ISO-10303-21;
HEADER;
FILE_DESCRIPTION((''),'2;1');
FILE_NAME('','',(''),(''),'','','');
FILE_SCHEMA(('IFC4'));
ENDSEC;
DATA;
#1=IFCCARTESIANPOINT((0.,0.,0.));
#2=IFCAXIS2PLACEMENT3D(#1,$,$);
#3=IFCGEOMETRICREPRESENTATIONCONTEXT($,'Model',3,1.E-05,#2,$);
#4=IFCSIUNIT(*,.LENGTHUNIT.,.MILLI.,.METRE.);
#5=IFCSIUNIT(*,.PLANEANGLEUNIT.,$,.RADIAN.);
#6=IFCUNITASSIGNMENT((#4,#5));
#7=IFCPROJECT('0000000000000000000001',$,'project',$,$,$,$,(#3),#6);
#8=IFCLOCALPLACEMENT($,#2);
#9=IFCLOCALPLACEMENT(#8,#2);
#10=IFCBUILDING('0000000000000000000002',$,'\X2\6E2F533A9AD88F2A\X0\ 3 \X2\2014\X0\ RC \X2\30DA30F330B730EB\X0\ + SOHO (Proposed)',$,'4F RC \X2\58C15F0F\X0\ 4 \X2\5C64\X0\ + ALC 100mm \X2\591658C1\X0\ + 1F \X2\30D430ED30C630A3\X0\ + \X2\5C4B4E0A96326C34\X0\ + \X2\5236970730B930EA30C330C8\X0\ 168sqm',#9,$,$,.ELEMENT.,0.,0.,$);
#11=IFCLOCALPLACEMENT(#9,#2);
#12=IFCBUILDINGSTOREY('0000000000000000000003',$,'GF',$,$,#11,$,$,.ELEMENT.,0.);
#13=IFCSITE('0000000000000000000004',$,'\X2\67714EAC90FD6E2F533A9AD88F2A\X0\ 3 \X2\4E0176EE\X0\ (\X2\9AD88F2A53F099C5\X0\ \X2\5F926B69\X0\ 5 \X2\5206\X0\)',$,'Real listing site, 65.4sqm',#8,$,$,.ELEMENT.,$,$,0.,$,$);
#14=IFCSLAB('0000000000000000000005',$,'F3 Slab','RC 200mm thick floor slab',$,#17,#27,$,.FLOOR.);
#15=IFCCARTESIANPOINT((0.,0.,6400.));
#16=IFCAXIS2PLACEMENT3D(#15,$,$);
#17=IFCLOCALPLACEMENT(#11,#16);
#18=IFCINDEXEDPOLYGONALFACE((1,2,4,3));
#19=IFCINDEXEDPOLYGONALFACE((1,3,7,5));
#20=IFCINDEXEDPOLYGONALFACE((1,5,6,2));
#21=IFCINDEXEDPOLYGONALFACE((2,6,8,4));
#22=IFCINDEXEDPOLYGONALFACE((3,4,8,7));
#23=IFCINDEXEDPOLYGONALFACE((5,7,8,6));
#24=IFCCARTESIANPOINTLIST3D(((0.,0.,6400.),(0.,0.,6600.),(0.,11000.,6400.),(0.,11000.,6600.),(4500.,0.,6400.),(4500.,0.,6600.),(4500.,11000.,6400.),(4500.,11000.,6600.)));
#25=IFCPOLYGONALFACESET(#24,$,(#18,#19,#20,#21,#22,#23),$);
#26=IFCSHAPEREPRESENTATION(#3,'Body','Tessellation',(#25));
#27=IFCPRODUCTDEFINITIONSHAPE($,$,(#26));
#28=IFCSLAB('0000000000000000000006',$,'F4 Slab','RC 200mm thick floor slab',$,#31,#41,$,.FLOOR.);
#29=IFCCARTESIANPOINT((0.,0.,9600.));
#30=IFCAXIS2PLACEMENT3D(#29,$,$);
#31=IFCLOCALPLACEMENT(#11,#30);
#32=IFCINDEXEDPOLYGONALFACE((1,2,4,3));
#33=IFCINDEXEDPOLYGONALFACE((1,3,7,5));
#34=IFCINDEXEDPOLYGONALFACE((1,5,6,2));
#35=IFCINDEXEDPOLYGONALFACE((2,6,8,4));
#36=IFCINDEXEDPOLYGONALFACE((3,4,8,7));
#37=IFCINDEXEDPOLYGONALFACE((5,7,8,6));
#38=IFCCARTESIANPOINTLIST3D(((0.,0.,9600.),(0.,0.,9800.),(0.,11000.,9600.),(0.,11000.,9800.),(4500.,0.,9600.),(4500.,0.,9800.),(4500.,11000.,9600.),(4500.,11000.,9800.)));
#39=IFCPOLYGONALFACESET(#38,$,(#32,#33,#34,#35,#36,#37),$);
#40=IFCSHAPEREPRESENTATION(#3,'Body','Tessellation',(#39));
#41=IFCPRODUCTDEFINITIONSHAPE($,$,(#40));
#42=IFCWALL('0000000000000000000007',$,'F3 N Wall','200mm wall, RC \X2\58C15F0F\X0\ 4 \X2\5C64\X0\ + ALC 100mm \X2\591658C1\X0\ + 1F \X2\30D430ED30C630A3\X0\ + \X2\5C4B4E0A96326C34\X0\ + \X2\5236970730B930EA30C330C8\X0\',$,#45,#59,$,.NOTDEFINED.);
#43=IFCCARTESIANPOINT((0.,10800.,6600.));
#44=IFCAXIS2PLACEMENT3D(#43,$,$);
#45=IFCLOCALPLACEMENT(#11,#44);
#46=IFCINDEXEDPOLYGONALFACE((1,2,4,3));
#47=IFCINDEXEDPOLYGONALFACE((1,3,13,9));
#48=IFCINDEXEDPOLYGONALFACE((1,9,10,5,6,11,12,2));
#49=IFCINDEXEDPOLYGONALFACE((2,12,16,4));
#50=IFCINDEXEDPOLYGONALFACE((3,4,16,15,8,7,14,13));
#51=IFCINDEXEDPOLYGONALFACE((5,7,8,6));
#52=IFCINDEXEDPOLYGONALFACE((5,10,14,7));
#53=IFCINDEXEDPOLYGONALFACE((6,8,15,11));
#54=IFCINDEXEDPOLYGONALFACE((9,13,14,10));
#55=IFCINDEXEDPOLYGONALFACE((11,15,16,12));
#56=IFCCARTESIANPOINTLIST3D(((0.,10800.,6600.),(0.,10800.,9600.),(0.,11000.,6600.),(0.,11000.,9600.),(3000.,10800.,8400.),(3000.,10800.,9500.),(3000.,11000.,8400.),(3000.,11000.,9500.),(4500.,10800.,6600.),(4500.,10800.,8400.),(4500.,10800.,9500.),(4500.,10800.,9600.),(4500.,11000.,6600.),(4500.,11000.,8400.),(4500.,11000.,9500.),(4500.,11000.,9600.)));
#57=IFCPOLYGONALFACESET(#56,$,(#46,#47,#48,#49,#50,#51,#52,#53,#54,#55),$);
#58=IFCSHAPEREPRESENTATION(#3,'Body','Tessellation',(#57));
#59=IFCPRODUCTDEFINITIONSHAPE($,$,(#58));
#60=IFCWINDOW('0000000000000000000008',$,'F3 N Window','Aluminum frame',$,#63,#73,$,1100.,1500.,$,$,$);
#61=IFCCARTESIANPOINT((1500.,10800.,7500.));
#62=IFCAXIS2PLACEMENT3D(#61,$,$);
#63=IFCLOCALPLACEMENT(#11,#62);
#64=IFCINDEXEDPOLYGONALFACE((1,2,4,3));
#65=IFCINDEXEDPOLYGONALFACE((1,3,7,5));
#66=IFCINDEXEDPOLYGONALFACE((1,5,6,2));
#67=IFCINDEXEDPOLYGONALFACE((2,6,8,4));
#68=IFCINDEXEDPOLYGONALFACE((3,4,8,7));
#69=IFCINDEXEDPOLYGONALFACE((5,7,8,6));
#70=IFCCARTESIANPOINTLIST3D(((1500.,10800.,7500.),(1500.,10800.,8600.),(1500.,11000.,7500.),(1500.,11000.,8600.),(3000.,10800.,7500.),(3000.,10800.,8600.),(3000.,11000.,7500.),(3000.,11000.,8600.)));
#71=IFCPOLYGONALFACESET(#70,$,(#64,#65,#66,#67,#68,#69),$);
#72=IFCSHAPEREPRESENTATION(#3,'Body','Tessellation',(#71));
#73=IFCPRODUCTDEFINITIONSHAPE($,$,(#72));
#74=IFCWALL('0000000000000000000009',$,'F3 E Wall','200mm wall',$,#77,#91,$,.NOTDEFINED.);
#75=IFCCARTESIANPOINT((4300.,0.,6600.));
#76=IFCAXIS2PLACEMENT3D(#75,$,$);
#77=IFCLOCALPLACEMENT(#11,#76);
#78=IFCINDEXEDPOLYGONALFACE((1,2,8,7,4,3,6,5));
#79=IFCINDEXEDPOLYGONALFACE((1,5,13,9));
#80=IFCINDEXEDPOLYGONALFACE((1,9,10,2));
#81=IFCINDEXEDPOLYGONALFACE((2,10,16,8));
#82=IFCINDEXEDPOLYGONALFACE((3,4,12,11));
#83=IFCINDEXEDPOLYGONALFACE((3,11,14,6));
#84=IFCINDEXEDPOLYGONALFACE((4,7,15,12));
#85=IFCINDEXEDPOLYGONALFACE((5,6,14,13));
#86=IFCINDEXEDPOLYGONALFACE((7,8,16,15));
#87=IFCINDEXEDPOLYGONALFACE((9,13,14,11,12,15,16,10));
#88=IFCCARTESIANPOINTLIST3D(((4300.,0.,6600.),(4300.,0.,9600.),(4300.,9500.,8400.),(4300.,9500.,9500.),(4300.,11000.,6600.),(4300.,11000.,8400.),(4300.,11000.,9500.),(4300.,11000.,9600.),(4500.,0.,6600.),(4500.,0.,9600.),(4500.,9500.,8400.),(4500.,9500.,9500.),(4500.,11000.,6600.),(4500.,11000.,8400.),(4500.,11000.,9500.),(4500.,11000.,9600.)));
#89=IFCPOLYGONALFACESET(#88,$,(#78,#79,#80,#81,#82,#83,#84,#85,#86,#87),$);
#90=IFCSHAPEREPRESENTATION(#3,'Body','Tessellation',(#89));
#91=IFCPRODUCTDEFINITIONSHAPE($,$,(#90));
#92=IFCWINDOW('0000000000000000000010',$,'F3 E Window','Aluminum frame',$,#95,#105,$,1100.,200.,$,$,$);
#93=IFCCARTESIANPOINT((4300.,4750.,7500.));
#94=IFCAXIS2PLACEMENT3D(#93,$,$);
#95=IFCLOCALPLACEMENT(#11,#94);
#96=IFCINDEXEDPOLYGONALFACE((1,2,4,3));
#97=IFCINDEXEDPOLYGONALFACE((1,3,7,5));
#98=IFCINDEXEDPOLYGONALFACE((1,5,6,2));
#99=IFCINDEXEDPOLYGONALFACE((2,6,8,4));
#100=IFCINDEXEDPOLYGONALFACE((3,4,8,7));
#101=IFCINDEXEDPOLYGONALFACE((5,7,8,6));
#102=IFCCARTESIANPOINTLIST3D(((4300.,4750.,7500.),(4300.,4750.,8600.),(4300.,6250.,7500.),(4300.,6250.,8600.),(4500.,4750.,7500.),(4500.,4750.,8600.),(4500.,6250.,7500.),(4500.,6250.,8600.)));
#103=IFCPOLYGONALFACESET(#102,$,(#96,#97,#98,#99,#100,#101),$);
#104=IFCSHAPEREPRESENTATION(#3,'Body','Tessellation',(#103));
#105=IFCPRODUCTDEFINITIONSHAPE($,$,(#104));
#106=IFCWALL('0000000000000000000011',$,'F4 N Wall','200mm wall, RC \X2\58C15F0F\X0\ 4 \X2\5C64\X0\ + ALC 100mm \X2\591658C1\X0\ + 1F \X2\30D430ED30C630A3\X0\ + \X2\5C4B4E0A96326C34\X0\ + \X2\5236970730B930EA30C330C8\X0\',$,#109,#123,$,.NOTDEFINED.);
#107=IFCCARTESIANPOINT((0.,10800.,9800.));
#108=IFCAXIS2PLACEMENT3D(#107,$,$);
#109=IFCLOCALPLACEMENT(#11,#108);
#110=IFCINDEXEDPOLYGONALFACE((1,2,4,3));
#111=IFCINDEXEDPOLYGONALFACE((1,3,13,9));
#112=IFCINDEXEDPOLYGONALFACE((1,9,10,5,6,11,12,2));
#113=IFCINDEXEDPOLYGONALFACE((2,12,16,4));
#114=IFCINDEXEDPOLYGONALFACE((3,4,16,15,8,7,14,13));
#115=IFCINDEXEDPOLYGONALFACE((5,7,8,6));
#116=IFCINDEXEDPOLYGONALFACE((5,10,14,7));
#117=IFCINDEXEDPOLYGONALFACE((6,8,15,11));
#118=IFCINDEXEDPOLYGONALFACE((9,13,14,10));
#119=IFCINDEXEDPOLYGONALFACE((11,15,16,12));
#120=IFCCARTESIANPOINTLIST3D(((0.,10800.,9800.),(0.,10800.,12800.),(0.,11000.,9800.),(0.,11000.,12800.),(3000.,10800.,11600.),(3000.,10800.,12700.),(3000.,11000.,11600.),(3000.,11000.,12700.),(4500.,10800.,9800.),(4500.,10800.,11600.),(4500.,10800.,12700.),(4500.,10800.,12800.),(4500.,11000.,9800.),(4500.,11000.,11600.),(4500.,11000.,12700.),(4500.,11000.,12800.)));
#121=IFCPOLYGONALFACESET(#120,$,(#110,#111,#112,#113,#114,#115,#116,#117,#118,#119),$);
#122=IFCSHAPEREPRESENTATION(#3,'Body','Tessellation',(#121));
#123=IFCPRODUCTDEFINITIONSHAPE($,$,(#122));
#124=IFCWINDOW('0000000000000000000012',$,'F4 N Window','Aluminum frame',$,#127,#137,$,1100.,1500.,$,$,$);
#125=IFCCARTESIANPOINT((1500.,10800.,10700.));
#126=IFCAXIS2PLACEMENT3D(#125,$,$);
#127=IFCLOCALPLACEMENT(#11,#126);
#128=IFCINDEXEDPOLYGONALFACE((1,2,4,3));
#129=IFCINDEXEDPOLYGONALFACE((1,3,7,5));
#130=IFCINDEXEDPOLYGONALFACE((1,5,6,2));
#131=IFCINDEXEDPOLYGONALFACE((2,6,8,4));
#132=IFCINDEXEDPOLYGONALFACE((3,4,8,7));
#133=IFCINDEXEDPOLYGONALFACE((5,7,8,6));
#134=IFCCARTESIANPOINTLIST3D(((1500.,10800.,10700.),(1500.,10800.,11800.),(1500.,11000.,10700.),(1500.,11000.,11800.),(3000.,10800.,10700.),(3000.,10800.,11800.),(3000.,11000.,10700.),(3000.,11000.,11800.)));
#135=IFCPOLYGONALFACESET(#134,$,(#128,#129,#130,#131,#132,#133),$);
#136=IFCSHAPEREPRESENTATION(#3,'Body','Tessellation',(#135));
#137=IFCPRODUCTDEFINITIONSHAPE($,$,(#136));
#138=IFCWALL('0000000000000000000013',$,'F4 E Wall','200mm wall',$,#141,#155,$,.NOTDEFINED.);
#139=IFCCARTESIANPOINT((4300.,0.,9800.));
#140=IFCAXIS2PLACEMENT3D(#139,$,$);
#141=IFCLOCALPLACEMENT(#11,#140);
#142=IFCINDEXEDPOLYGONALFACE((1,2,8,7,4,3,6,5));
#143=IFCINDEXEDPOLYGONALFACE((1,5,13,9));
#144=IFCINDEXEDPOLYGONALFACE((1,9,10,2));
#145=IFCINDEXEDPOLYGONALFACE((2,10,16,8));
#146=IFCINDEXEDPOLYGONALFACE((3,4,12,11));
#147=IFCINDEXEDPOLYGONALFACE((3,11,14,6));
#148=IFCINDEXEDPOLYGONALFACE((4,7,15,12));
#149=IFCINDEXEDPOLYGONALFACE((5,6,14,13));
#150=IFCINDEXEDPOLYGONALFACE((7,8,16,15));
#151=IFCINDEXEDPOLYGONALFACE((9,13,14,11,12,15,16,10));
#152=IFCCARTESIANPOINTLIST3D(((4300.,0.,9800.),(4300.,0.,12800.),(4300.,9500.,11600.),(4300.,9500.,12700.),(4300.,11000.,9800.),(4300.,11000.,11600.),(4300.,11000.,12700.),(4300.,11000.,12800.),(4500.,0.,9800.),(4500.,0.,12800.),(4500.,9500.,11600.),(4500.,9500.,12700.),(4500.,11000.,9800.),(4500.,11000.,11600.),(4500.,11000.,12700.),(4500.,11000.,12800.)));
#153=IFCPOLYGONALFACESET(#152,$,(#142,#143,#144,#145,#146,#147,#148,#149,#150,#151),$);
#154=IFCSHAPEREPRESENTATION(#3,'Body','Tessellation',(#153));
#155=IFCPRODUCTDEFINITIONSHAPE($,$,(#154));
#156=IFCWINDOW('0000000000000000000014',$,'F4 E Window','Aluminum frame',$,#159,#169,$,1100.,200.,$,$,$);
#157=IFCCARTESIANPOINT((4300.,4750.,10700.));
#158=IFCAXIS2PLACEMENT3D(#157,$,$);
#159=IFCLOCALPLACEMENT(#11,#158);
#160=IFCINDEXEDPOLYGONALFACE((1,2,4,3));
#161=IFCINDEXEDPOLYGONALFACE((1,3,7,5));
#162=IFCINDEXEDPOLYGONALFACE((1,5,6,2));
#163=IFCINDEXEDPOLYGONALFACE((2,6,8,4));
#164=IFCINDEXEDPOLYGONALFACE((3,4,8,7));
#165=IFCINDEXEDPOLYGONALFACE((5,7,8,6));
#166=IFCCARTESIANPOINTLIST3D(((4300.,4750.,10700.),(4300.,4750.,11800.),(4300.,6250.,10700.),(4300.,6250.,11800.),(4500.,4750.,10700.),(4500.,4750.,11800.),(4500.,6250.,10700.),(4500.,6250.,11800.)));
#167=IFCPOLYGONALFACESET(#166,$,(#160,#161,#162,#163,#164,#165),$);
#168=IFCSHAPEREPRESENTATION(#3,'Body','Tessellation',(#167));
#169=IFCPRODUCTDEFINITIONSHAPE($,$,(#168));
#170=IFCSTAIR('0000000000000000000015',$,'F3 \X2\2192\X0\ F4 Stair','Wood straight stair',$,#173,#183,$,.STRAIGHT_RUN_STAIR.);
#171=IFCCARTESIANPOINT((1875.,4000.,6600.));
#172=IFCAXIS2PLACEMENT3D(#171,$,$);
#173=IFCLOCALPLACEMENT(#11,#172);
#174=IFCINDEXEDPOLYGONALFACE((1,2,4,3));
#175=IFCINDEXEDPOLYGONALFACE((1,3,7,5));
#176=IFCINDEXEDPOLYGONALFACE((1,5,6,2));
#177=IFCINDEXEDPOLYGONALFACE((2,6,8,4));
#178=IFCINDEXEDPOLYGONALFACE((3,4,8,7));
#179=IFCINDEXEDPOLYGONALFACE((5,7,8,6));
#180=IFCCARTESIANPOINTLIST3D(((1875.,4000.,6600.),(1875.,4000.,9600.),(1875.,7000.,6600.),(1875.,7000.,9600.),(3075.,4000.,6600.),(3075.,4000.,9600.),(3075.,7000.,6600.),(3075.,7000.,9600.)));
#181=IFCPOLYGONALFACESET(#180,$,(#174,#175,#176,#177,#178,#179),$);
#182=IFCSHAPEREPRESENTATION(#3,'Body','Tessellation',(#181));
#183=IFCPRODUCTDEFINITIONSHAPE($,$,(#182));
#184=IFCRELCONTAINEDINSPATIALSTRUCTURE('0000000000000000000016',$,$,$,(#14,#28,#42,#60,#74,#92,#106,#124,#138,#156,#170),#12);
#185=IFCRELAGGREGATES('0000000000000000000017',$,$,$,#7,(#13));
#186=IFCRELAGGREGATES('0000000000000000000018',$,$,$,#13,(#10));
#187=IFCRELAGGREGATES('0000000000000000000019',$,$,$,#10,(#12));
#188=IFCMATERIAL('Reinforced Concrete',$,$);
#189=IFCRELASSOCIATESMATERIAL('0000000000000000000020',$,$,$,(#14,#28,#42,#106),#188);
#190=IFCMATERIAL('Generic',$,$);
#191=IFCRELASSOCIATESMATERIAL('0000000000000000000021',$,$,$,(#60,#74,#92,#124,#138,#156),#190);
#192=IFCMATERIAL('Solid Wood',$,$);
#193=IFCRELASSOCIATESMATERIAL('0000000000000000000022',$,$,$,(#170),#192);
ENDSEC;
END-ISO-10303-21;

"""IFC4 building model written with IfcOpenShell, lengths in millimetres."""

from ifc_helpers import new_model, si_unit, frame, frame_2d, origin, place, context, project, spatial, rectangle, extrude, material, element, fill, save


model = new_model("IFC4")

# Units and contexts
model_context = context("Model", 3, precision=1e-05, world=origin())
ifc_project = project(units=[si_unit("LENGTHUNIT", "METRE", prefix="MILLI"), si_unit("PLANEANGLEUNIT", "RADIAN")], contexts=[model_context])

# Site, building, storey
site_placement = place(None, origin())
site = spatial("IfcSite", under=ifc_project, at=site_placement, Name="東京都港区高輪 3 丁目 (高輪台駅 徒歩 5 分)", ObjectType="Real listing site, 65.4sqm", CompositionType="ELEMENT", RefElevation=0.0)
building_placement = place(site_placement, origin())
building = spatial("IfcBuilding", under=site, at=building_placement, Name="港区高輪 3 — RC ペンシル + SOHO (Proposed)", ObjectType="4F RC 壁式 4 層 + ALC 100mm 外壁 + 1F ピロティ + 屋上防水 + 制震スリット 168sqm", CompositionType="ELEMENT", ElevationOfRefHeight=0.0, ElevationOfTerrain=0.0)
storey_placement = place(building_placement, origin())
storey = spatial("IfcBuildingStorey", under=building, at=storey_placement, Name="GF", CompositionType="ELEMENT", Elevation=0.0)

# Slabs
ifc_material_1 = material(Name="Reinforced Concrete")
slab_1_placement = place(storey_placement, frame((0.0, 0.0, 6400.0)))
element("IfcSlab", 1, at=slab_1_placement, inside=storey, material=ifc_material_1, Name="F3 Slab", Description="RC 200mm thick floor slab", PredefinedType="FLOOR", context=model_context, shape_type="SweptSolid", body=[
    extrude(rectangle(XDim=4500.0, YDim=11000.0, at=frame_2d((2250.0, 5500.0))), frame((0.0, 0.0, 6400.0)), (0.0, 0.0, 1.0), 200.0),
])
slab_2_placement = place(storey_placement, frame((0.0, 0.0, 9600.0)))
element("IfcSlab", 2, at=slab_2_placement, inside=storey, material=ifc_material_1, Name="F4 Slab", Description="RC 200mm thick floor slab", PredefinedType="FLOOR", context=model_context, shape_type="SweptSolid", body=[
    extrude(rectangle(XDim=4500.0, YDim=11000.0, at=frame_2d((2250.0, 5500.0))), frame((0.0, 0.0, 9600.0)), (0.0, 0.0, 1.0), 200.0),
])

# Walls, openings, windows
wall_1_placement = place(storey_placement, frame((0.0, 10800.0, 6600.0)))
wall_1 = element("IfcWall", 3, at=wall_1_placement, inside=storey, material=ifc_material_1, Name="F3 N Wall", Description="200mm wall, RC 壁式 4 層 + ALC 100mm 外壁 + 1F ピロティ + 屋上防水 + 制震スリット", PredefinedType="NOTDEFINED", context=model_context, shape_type="SweptSolid", body=[
    extrude(rectangle(XDim=4500.0, YDim=200.0, at=frame_2d((2250.0, 100.0))), frame((0.0, 10800.0, 6600.0)), (0.0, 0.0, 1.0), 3000.0),
])
opening_1_placement = place(storey_placement, frame((1500.0, 10800.0, 7500.0)))
opening_1 = element("IfcOpeningElement", 4, at=opening_1_placement, cuts=wall_1, PredefinedType="NOTDEFINED", context=model_context, shape_type="SweptSolid", body=[
    extrude(rectangle(XDim=1500.0, YDim=200.0, at=frame_2d((750.0, 100.0))), frame((1500.0, 10800.0, 7500.0)), (0.0, 0.0, 1.0), 1100.0),
])
ifc_material_2 = material(Name="Generic")
window_1_placement = place(storey_placement, frame((1500.0, 10800.0, 7500.0)))
window_1 = element("IfcWindow", 5, at=window_1_placement, inside=storey, material=ifc_material_2, Name="F3 N Window", Description="Aluminum frame", OverallHeight=1100.0, OverallWidth=1500.0, context=model_context, shape_type="SweptSolid", body=[
    extrude(rectangle(XDim=1500.0, YDim=200.0, at=frame_2d((750.0, 100.0))), frame((1500.0, 10800.0, 7500.0)), (0.0, 0.0, 1.0), 1100.0),
])
fill(opening_1, window_1)
wall_2_placement = place(storey_placement, frame((4300.0, 0.0, 6600.0)))
wall_2 = element("IfcWall", 6, at=wall_2_placement, inside=storey, material=ifc_material_2, Name="F3 E Wall", Description="200mm wall", PredefinedType="NOTDEFINED", context=model_context, shape_type="SweptSolid", body=[
    extrude(rectangle(XDim=200.0, YDim=11000.0, at=frame_2d((100.0, 5500.0))), frame((4300.0, 0.0, 6600.0)), (0.0, 0.0, 1.0), 3000.0),
])
opening_2_placement = place(storey_placement, frame((4300.0, 4750.0, 7500.0)))
opening_2 = element("IfcOpeningElement", 7, at=opening_2_placement, cuts=wall_2, PredefinedType="NOTDEFINED", context=model_context, shape_type="SweptSolid", body=[
    extrude(rectangle(XDim=200.0, YDim=1500.0, at=frame_2d((100.0, 750.0))), frame((4300.0, 4750.0, 7500.0)), (0.0, 0.0, 1.0), 1100.0),
])
window_2_placement = place(storey_placement, frame((4300.0, 4750.0, 7500.0)))
window_2 = element("IfcWindow", 8, at=window_2_placement, inside=storey, material=ifc_material_2, Name="F3 E Window", Description="Aluminum frame", OverallHeight=1100.0, OverallWidth=200.0, context=model_context, shape_type="SweptSolid", body=[
    extrude(rectangle(XDim=200.0, YDim=1500.0, at=frame_2d((100.0, 750.0))), frame((4300.0, 4750.0, 7500.0)), (0.0, 0.0, 1.0), 1100.0),
])
fill(opening_2, window_2)
wall_3_placement = place(storey_placement, frame((0.0, 10800.0, 9800.0)))
wall_3 = element("IfcWall", 9, at=wall_3_placement, inside=storey, material=ifc_material_1, Name="F4 N Wall", Description="200mm wall, RC 壁式 4 層 + ALC 100mm 外壁 + 1F ピロティ + 屋上防水 + 制震スリット", PredefinedType="NOTDEFINED", context=model_context, shape_type="SweptSolid", body=[
    extrude(rectangle(XDim=4500.0, YDim=200.0, at=frame_2d((2250.0, 100.0))), frame((0.0, 10800.0, 9800.0)), (0.0, 0.0, 1.0), 3000.0),
])
opening_3_placement = place(storey_placement, frame((1500.0, 10800.0, 10700.0)))
opening_3 = element("IfcOpeningElement", 10, at=opening_3_placement, cuts=wall_3, PredefinedType="NOTDEFINED", context=model_context, shape_type="SweptSolid", body=[
    extrude(rectangle(XDim=1500.0, YDim=200.0, at=frame_2d((750.0, 100.0))), frame((1500.0, 10800.0, 10700.0)), (0.0, 0.0, 1.0), 1100.0),
])
window_3_placement = place(storey_placement, frame((1500.0, 10800.0, 10700.0)))
window_3 = element("IfcWindow", 11, at=window_3_placement, inside=storey, material=ifc_material_2, Name="F4 N Window", Description="Aluminum frame", OverallHeight=1100.0, OverallWidth=1500.0, context=model_context, shape_type="SweptSolid", body=[
    extrude(rectangle(XDim=1500.0, YDim=200.0, at=frame_2d((750.0, 100.0))), frame((1500.0, 10800.0, 10700.0)), (0.0, 0.0, 1.0), 1100.0),
])
fill(opening_3, window_3)
wall_4_placement = place(storey_placement, frame((4300.0, 0.0, 9800.0)))
wall_4 = element("IfcWall", 12, at=wall_4_placement, inside=storey, material=ifc_material_2, Name="F4 E Wall", Description="200mm wall", PredefinedType="NOTDEFINED", context=model_context, shape_type="SweptSolid", body=[
    extrude(rectangle(XDim=200.0, YDim=11000.0, at=frame_2d((100.0, 5500.0))), frame((4300.0, 0.0, 9800.0)), (0.0, 0.0, 1.0), 3000.0),
])
opening_4_placement = place(storey_placement, frame((4300.0, 4750.0, 10700.0)))
opening_4 = element("IfcOpeningElement", 13, at=opening_4_placement, cuts=wall_4, PredefinedType="NOTDEFINED", context=model_context, shape_type="SweptSolid", body=[
    extrude(rectangle(XDim=200.0, YDim=1500.0, at=frame_2d((100.0, 750.0))), frame((4300.0, 4750.0, 10700.0)), (0.0, 0.0, 1.0), 1100.0),
])
window_4_placement = place(storey_placement, frame((4300.0, 4750.0, 10700.0)))
window_4 = element("IfcWindow", 14, at=window_4_placement, inside=storey, material=ifc_material_2, Name="F4 E Window", Description="Aluminum frame", OverallHeight=1100.0, OverallWidth=200.0, context=model_context, shape_type="SweptSolid", body=[
    extrude(rectangle(XDim=200.0, YDim=1500.0, at=frame_2d((100.0, 750.0))), frame((4300.0, 4750.0, 10700.0)), (0.0, 0.0, 1.0), 1100.0),
])
fill(opening_4, window_4)

# Stair
ifc_material_3 = material(Name="Solid Wood")
stair_placement = place(storey_placement, frame((1875.0, 4000.0, 6600.0)))
element("IfcStair", 15, at=stair_placement, inside=storey, material=ifc_material_3, Name="F3 → F4 Stair", Description="Wood straight stair", PredefinedType="STRAIGHT_RUN_STAIR", context=model_context, shape_type="SweptSolid", body=[
    extrude(rectangle(XDim=1200.0, YDim=3000.0, at=frame_2d((600.0, 1500.0))), frame((1875.0, 4000.0, 6600.0)), (0.0, 0.0, 1.0), 3000.0),
])

save(model, "model.ifc")
